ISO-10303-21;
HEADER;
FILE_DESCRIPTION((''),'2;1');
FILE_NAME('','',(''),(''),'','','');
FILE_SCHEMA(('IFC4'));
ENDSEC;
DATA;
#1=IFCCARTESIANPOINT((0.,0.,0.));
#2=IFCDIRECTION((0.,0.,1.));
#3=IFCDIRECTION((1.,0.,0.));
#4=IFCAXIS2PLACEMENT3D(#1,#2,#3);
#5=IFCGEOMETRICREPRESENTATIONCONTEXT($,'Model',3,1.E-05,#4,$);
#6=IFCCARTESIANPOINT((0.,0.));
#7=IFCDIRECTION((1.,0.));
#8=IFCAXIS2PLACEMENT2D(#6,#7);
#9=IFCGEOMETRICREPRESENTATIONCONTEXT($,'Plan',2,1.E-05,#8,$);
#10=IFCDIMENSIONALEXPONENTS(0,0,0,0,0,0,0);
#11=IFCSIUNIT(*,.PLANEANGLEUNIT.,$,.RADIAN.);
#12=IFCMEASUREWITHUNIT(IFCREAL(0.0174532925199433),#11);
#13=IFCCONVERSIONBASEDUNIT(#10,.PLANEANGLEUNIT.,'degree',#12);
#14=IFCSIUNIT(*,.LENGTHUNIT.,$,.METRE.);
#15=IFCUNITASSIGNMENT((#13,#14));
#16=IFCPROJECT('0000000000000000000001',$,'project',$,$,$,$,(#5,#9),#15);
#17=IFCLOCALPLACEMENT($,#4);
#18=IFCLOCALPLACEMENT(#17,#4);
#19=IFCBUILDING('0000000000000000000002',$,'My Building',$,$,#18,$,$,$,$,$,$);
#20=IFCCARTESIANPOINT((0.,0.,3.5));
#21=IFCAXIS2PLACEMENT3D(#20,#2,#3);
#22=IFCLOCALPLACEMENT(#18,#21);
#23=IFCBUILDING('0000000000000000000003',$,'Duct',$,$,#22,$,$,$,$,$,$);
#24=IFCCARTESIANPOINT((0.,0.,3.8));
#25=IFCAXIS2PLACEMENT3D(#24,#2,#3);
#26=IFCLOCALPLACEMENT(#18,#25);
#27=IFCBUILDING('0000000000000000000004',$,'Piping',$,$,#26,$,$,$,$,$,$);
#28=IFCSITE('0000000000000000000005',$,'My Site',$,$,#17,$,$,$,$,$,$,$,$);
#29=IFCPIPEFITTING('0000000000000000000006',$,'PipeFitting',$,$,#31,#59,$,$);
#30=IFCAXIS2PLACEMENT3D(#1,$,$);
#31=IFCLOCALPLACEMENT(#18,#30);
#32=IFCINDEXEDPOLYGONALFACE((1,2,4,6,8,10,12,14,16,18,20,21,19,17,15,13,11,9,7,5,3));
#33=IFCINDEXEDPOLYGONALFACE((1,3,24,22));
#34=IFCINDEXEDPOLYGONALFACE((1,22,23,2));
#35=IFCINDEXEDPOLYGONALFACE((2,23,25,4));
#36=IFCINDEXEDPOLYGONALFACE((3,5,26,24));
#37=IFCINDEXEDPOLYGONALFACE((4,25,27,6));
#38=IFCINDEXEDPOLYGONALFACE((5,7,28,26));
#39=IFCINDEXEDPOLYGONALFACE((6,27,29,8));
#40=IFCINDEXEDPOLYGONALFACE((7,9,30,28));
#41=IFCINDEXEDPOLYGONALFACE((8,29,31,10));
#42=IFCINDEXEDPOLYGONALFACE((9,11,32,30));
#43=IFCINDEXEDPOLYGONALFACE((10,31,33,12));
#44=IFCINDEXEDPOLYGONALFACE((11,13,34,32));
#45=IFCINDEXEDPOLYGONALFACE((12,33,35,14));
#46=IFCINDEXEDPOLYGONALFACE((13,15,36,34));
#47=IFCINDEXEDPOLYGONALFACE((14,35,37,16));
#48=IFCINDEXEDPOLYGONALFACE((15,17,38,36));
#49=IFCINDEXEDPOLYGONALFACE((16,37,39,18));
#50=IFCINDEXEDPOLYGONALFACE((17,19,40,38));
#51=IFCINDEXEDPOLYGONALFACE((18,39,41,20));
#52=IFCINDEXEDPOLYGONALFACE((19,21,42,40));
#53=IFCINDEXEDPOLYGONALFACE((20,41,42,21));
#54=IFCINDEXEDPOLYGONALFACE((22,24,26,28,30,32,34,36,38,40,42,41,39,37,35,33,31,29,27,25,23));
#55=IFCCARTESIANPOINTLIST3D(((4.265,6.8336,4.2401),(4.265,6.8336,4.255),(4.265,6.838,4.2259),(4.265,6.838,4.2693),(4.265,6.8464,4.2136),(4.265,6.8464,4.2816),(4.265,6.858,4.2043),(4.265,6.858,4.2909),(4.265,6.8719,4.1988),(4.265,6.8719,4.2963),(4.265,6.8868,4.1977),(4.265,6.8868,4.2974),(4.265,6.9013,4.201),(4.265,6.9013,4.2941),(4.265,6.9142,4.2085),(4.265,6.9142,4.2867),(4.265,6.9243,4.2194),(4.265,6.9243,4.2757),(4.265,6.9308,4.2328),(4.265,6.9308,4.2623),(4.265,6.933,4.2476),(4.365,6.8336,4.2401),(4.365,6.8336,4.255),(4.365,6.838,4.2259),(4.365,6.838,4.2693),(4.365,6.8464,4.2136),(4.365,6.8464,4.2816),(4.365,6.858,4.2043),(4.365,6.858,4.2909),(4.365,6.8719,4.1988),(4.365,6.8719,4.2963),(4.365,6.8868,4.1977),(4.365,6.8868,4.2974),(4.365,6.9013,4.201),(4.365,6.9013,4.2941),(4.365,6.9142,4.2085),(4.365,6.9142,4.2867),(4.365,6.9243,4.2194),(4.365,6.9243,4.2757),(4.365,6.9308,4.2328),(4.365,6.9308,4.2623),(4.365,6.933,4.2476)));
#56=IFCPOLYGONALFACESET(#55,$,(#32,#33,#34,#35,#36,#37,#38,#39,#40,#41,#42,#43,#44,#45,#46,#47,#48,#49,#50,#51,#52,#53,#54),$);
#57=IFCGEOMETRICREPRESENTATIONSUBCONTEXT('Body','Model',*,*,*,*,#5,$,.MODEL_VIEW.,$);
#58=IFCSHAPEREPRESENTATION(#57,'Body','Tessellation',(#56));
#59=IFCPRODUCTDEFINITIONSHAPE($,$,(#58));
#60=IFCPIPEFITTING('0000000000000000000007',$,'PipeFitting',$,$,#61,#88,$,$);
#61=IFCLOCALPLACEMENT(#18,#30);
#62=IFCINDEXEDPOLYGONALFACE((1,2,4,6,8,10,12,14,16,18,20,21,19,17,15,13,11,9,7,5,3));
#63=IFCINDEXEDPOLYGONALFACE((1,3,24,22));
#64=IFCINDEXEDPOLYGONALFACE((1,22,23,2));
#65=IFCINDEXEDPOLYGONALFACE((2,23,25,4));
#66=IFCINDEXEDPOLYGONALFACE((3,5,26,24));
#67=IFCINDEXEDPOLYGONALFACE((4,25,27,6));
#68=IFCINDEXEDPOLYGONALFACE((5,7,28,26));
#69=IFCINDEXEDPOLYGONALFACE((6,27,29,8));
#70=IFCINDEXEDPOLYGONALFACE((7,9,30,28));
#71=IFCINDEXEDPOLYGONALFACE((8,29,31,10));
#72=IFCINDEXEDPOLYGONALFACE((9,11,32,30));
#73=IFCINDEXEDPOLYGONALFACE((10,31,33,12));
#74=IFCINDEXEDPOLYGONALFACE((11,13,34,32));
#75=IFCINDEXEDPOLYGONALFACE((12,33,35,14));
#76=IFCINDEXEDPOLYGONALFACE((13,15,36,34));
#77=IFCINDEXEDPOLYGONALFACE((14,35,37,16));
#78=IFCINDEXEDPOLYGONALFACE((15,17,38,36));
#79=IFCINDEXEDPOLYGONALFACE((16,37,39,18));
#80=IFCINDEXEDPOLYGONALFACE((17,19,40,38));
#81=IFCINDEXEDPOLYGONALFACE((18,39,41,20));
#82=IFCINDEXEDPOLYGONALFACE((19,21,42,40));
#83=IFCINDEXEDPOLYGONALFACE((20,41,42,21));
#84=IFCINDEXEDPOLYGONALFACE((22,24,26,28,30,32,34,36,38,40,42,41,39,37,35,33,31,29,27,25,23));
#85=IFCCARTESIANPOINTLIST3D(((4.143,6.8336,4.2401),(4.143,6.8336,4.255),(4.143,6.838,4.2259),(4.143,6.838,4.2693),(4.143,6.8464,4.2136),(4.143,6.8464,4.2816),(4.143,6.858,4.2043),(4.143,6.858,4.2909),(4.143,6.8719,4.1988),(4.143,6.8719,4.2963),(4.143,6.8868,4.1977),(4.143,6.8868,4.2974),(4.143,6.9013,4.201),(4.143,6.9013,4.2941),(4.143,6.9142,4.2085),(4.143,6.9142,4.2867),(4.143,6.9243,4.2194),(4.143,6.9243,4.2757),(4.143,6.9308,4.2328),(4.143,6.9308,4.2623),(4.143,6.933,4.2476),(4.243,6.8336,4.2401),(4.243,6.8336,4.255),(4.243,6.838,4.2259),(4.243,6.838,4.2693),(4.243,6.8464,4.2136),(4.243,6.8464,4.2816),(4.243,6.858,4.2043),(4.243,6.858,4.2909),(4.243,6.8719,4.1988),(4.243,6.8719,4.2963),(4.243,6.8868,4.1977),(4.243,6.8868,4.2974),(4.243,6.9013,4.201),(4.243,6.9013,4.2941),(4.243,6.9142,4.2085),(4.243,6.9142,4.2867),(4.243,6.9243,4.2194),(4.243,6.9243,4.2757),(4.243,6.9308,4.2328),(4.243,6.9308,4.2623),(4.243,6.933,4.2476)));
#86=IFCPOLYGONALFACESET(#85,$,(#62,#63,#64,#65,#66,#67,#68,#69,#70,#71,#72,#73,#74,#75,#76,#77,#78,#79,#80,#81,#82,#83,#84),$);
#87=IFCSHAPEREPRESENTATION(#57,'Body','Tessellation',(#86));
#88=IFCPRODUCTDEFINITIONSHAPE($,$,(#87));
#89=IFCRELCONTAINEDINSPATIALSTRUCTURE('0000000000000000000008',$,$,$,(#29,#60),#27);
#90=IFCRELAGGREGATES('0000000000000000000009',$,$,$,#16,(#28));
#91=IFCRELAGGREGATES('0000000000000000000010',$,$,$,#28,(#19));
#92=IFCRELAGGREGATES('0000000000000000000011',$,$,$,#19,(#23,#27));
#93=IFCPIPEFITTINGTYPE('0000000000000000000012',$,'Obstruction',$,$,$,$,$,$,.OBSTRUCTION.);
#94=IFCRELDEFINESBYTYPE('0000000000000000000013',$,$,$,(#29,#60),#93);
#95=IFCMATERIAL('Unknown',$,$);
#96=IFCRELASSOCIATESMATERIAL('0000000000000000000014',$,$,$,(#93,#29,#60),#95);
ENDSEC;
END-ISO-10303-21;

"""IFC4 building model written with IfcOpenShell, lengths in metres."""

from ifc_helpers import new_model, entity, si_unit, converted_unit, frame, origin_with_axes, origin_2d_with_axis, place, context, subcontext, project, spatial, circle, extrude, material, material_profile, profile_set, profile_usage, type_object, element, save


model = new_model("IFC4")

# Units and contexts
model_context = context("Model", 3, precision=1e-05, world=origin_with_axes())
plan_context = context("Plan", 2, precision=1e-05, world=origin_2d_with_axis())
body_context = subcontext(model_context, "Body", "Model", "MODEL_VIEW")
ifc_project = project(units=[converted_unit("PLANEANGLEUNIT", "degree", entity("IfcReal", 0.0174532925199433), si_unit("PLANEANGLEUNIT", "RADIAN"), dimensions=[0, 0, 0, 0, 0, 0, 0]), si_unit("LENGTHUNIT", "METRE")], contexts=[model_context, plan_context])

# Site, building
site_placement = place(None, origin_with_axes())
site = spatial("IfcSite", under=ifc_project, at=site_placement, Name="My Site")
building_1_placement = place(site_placement, origin_with_axes())
building_1 = spatial("IfcBuilding", under=site, at=building_1_placement, Name="My Building")

# Shared definitions
ifc_material = material(Name="Unknown")

# Shared definitions
building_2_placement = place(building_1_placement, frame((0.0, 0.0, 3.5), z_axis=(0.0, 0.0, 1.0), x_axis=(1.0, 0.0, 0.0)))
building_2 = spatial("IfcBuilding", under=building_1, at=building_2_placement, Name="Duct")

# Shared definitions
building_3_placement = place(building_1_placement, frame((0.0, 0.0, 3.8), z_axis=(0.0, 0.0, 1.0), x_axis=(1.0, 0.0, 0.0)))
building_3 = spatial("IfcBuilding", under=building_1, at=building_3_placement, Name="Piping")

# Pipe fittings
ifc_material_profile_1 = material_profile(ifc_material, circle(Radius=0.05))
ifc_profile_set_1 = profile_set([ifc_material_profile_1])
ifc_profile_usage_1 = profile_usage(ifc_profile_set_1, cardinal=5)
pipe_fitting_type_1 = type_object("IfcPipeFittingType", Name="Obstruction", PredefinedType="OBSTRUCTION", material=ifc_profile_set_1)
pipe_fitting_1_placement = place(building_3_placement, frame((4.265, 6.883, 0.4476), z_axis=(1.0, -0.000001, 0.000001), x_axis=(0.000001, 1.0, 0.0)))
element("IfcPipeFitting", 1, at=pipe_fitting_1_placement, inside=building_3, type_object=pipe_fitting_type_1, material=ifc_profile_usage_1, Name="PipeFitting", context=body_context, shape_type="SweptSolid", body=[
    extrude(circle(Radius=0.05), origin_with_axes(), (0.0, 0.0, 1.0), 0.1),
])
ifc_profile_usage_2 = profile_usage(ifc_profile_set_1, cardinal=5)
pipe_fitting_2_placement = place(building_3_placement, frame((4.243, 6.883, 0.4476), z_axis=(-1.0, -0.000001, -0.000001), x_axis=(-0.000001, 1.0, 0.0)))
element("IfcPipeFitting", 2, at=pipe_fitting_2_placement, inside=building_3, type_object=pipe_fitting_type_1, material=ifc_profile_usage_2, Name="PipeFitting", context=body_context, shape_type="SweptSolid", body=[
    extrude(circle(Radius=0.05), origin_with_axes(), (0.0, 0.0, 1.0), 0.1),
])

save(model, "model.ifc")
